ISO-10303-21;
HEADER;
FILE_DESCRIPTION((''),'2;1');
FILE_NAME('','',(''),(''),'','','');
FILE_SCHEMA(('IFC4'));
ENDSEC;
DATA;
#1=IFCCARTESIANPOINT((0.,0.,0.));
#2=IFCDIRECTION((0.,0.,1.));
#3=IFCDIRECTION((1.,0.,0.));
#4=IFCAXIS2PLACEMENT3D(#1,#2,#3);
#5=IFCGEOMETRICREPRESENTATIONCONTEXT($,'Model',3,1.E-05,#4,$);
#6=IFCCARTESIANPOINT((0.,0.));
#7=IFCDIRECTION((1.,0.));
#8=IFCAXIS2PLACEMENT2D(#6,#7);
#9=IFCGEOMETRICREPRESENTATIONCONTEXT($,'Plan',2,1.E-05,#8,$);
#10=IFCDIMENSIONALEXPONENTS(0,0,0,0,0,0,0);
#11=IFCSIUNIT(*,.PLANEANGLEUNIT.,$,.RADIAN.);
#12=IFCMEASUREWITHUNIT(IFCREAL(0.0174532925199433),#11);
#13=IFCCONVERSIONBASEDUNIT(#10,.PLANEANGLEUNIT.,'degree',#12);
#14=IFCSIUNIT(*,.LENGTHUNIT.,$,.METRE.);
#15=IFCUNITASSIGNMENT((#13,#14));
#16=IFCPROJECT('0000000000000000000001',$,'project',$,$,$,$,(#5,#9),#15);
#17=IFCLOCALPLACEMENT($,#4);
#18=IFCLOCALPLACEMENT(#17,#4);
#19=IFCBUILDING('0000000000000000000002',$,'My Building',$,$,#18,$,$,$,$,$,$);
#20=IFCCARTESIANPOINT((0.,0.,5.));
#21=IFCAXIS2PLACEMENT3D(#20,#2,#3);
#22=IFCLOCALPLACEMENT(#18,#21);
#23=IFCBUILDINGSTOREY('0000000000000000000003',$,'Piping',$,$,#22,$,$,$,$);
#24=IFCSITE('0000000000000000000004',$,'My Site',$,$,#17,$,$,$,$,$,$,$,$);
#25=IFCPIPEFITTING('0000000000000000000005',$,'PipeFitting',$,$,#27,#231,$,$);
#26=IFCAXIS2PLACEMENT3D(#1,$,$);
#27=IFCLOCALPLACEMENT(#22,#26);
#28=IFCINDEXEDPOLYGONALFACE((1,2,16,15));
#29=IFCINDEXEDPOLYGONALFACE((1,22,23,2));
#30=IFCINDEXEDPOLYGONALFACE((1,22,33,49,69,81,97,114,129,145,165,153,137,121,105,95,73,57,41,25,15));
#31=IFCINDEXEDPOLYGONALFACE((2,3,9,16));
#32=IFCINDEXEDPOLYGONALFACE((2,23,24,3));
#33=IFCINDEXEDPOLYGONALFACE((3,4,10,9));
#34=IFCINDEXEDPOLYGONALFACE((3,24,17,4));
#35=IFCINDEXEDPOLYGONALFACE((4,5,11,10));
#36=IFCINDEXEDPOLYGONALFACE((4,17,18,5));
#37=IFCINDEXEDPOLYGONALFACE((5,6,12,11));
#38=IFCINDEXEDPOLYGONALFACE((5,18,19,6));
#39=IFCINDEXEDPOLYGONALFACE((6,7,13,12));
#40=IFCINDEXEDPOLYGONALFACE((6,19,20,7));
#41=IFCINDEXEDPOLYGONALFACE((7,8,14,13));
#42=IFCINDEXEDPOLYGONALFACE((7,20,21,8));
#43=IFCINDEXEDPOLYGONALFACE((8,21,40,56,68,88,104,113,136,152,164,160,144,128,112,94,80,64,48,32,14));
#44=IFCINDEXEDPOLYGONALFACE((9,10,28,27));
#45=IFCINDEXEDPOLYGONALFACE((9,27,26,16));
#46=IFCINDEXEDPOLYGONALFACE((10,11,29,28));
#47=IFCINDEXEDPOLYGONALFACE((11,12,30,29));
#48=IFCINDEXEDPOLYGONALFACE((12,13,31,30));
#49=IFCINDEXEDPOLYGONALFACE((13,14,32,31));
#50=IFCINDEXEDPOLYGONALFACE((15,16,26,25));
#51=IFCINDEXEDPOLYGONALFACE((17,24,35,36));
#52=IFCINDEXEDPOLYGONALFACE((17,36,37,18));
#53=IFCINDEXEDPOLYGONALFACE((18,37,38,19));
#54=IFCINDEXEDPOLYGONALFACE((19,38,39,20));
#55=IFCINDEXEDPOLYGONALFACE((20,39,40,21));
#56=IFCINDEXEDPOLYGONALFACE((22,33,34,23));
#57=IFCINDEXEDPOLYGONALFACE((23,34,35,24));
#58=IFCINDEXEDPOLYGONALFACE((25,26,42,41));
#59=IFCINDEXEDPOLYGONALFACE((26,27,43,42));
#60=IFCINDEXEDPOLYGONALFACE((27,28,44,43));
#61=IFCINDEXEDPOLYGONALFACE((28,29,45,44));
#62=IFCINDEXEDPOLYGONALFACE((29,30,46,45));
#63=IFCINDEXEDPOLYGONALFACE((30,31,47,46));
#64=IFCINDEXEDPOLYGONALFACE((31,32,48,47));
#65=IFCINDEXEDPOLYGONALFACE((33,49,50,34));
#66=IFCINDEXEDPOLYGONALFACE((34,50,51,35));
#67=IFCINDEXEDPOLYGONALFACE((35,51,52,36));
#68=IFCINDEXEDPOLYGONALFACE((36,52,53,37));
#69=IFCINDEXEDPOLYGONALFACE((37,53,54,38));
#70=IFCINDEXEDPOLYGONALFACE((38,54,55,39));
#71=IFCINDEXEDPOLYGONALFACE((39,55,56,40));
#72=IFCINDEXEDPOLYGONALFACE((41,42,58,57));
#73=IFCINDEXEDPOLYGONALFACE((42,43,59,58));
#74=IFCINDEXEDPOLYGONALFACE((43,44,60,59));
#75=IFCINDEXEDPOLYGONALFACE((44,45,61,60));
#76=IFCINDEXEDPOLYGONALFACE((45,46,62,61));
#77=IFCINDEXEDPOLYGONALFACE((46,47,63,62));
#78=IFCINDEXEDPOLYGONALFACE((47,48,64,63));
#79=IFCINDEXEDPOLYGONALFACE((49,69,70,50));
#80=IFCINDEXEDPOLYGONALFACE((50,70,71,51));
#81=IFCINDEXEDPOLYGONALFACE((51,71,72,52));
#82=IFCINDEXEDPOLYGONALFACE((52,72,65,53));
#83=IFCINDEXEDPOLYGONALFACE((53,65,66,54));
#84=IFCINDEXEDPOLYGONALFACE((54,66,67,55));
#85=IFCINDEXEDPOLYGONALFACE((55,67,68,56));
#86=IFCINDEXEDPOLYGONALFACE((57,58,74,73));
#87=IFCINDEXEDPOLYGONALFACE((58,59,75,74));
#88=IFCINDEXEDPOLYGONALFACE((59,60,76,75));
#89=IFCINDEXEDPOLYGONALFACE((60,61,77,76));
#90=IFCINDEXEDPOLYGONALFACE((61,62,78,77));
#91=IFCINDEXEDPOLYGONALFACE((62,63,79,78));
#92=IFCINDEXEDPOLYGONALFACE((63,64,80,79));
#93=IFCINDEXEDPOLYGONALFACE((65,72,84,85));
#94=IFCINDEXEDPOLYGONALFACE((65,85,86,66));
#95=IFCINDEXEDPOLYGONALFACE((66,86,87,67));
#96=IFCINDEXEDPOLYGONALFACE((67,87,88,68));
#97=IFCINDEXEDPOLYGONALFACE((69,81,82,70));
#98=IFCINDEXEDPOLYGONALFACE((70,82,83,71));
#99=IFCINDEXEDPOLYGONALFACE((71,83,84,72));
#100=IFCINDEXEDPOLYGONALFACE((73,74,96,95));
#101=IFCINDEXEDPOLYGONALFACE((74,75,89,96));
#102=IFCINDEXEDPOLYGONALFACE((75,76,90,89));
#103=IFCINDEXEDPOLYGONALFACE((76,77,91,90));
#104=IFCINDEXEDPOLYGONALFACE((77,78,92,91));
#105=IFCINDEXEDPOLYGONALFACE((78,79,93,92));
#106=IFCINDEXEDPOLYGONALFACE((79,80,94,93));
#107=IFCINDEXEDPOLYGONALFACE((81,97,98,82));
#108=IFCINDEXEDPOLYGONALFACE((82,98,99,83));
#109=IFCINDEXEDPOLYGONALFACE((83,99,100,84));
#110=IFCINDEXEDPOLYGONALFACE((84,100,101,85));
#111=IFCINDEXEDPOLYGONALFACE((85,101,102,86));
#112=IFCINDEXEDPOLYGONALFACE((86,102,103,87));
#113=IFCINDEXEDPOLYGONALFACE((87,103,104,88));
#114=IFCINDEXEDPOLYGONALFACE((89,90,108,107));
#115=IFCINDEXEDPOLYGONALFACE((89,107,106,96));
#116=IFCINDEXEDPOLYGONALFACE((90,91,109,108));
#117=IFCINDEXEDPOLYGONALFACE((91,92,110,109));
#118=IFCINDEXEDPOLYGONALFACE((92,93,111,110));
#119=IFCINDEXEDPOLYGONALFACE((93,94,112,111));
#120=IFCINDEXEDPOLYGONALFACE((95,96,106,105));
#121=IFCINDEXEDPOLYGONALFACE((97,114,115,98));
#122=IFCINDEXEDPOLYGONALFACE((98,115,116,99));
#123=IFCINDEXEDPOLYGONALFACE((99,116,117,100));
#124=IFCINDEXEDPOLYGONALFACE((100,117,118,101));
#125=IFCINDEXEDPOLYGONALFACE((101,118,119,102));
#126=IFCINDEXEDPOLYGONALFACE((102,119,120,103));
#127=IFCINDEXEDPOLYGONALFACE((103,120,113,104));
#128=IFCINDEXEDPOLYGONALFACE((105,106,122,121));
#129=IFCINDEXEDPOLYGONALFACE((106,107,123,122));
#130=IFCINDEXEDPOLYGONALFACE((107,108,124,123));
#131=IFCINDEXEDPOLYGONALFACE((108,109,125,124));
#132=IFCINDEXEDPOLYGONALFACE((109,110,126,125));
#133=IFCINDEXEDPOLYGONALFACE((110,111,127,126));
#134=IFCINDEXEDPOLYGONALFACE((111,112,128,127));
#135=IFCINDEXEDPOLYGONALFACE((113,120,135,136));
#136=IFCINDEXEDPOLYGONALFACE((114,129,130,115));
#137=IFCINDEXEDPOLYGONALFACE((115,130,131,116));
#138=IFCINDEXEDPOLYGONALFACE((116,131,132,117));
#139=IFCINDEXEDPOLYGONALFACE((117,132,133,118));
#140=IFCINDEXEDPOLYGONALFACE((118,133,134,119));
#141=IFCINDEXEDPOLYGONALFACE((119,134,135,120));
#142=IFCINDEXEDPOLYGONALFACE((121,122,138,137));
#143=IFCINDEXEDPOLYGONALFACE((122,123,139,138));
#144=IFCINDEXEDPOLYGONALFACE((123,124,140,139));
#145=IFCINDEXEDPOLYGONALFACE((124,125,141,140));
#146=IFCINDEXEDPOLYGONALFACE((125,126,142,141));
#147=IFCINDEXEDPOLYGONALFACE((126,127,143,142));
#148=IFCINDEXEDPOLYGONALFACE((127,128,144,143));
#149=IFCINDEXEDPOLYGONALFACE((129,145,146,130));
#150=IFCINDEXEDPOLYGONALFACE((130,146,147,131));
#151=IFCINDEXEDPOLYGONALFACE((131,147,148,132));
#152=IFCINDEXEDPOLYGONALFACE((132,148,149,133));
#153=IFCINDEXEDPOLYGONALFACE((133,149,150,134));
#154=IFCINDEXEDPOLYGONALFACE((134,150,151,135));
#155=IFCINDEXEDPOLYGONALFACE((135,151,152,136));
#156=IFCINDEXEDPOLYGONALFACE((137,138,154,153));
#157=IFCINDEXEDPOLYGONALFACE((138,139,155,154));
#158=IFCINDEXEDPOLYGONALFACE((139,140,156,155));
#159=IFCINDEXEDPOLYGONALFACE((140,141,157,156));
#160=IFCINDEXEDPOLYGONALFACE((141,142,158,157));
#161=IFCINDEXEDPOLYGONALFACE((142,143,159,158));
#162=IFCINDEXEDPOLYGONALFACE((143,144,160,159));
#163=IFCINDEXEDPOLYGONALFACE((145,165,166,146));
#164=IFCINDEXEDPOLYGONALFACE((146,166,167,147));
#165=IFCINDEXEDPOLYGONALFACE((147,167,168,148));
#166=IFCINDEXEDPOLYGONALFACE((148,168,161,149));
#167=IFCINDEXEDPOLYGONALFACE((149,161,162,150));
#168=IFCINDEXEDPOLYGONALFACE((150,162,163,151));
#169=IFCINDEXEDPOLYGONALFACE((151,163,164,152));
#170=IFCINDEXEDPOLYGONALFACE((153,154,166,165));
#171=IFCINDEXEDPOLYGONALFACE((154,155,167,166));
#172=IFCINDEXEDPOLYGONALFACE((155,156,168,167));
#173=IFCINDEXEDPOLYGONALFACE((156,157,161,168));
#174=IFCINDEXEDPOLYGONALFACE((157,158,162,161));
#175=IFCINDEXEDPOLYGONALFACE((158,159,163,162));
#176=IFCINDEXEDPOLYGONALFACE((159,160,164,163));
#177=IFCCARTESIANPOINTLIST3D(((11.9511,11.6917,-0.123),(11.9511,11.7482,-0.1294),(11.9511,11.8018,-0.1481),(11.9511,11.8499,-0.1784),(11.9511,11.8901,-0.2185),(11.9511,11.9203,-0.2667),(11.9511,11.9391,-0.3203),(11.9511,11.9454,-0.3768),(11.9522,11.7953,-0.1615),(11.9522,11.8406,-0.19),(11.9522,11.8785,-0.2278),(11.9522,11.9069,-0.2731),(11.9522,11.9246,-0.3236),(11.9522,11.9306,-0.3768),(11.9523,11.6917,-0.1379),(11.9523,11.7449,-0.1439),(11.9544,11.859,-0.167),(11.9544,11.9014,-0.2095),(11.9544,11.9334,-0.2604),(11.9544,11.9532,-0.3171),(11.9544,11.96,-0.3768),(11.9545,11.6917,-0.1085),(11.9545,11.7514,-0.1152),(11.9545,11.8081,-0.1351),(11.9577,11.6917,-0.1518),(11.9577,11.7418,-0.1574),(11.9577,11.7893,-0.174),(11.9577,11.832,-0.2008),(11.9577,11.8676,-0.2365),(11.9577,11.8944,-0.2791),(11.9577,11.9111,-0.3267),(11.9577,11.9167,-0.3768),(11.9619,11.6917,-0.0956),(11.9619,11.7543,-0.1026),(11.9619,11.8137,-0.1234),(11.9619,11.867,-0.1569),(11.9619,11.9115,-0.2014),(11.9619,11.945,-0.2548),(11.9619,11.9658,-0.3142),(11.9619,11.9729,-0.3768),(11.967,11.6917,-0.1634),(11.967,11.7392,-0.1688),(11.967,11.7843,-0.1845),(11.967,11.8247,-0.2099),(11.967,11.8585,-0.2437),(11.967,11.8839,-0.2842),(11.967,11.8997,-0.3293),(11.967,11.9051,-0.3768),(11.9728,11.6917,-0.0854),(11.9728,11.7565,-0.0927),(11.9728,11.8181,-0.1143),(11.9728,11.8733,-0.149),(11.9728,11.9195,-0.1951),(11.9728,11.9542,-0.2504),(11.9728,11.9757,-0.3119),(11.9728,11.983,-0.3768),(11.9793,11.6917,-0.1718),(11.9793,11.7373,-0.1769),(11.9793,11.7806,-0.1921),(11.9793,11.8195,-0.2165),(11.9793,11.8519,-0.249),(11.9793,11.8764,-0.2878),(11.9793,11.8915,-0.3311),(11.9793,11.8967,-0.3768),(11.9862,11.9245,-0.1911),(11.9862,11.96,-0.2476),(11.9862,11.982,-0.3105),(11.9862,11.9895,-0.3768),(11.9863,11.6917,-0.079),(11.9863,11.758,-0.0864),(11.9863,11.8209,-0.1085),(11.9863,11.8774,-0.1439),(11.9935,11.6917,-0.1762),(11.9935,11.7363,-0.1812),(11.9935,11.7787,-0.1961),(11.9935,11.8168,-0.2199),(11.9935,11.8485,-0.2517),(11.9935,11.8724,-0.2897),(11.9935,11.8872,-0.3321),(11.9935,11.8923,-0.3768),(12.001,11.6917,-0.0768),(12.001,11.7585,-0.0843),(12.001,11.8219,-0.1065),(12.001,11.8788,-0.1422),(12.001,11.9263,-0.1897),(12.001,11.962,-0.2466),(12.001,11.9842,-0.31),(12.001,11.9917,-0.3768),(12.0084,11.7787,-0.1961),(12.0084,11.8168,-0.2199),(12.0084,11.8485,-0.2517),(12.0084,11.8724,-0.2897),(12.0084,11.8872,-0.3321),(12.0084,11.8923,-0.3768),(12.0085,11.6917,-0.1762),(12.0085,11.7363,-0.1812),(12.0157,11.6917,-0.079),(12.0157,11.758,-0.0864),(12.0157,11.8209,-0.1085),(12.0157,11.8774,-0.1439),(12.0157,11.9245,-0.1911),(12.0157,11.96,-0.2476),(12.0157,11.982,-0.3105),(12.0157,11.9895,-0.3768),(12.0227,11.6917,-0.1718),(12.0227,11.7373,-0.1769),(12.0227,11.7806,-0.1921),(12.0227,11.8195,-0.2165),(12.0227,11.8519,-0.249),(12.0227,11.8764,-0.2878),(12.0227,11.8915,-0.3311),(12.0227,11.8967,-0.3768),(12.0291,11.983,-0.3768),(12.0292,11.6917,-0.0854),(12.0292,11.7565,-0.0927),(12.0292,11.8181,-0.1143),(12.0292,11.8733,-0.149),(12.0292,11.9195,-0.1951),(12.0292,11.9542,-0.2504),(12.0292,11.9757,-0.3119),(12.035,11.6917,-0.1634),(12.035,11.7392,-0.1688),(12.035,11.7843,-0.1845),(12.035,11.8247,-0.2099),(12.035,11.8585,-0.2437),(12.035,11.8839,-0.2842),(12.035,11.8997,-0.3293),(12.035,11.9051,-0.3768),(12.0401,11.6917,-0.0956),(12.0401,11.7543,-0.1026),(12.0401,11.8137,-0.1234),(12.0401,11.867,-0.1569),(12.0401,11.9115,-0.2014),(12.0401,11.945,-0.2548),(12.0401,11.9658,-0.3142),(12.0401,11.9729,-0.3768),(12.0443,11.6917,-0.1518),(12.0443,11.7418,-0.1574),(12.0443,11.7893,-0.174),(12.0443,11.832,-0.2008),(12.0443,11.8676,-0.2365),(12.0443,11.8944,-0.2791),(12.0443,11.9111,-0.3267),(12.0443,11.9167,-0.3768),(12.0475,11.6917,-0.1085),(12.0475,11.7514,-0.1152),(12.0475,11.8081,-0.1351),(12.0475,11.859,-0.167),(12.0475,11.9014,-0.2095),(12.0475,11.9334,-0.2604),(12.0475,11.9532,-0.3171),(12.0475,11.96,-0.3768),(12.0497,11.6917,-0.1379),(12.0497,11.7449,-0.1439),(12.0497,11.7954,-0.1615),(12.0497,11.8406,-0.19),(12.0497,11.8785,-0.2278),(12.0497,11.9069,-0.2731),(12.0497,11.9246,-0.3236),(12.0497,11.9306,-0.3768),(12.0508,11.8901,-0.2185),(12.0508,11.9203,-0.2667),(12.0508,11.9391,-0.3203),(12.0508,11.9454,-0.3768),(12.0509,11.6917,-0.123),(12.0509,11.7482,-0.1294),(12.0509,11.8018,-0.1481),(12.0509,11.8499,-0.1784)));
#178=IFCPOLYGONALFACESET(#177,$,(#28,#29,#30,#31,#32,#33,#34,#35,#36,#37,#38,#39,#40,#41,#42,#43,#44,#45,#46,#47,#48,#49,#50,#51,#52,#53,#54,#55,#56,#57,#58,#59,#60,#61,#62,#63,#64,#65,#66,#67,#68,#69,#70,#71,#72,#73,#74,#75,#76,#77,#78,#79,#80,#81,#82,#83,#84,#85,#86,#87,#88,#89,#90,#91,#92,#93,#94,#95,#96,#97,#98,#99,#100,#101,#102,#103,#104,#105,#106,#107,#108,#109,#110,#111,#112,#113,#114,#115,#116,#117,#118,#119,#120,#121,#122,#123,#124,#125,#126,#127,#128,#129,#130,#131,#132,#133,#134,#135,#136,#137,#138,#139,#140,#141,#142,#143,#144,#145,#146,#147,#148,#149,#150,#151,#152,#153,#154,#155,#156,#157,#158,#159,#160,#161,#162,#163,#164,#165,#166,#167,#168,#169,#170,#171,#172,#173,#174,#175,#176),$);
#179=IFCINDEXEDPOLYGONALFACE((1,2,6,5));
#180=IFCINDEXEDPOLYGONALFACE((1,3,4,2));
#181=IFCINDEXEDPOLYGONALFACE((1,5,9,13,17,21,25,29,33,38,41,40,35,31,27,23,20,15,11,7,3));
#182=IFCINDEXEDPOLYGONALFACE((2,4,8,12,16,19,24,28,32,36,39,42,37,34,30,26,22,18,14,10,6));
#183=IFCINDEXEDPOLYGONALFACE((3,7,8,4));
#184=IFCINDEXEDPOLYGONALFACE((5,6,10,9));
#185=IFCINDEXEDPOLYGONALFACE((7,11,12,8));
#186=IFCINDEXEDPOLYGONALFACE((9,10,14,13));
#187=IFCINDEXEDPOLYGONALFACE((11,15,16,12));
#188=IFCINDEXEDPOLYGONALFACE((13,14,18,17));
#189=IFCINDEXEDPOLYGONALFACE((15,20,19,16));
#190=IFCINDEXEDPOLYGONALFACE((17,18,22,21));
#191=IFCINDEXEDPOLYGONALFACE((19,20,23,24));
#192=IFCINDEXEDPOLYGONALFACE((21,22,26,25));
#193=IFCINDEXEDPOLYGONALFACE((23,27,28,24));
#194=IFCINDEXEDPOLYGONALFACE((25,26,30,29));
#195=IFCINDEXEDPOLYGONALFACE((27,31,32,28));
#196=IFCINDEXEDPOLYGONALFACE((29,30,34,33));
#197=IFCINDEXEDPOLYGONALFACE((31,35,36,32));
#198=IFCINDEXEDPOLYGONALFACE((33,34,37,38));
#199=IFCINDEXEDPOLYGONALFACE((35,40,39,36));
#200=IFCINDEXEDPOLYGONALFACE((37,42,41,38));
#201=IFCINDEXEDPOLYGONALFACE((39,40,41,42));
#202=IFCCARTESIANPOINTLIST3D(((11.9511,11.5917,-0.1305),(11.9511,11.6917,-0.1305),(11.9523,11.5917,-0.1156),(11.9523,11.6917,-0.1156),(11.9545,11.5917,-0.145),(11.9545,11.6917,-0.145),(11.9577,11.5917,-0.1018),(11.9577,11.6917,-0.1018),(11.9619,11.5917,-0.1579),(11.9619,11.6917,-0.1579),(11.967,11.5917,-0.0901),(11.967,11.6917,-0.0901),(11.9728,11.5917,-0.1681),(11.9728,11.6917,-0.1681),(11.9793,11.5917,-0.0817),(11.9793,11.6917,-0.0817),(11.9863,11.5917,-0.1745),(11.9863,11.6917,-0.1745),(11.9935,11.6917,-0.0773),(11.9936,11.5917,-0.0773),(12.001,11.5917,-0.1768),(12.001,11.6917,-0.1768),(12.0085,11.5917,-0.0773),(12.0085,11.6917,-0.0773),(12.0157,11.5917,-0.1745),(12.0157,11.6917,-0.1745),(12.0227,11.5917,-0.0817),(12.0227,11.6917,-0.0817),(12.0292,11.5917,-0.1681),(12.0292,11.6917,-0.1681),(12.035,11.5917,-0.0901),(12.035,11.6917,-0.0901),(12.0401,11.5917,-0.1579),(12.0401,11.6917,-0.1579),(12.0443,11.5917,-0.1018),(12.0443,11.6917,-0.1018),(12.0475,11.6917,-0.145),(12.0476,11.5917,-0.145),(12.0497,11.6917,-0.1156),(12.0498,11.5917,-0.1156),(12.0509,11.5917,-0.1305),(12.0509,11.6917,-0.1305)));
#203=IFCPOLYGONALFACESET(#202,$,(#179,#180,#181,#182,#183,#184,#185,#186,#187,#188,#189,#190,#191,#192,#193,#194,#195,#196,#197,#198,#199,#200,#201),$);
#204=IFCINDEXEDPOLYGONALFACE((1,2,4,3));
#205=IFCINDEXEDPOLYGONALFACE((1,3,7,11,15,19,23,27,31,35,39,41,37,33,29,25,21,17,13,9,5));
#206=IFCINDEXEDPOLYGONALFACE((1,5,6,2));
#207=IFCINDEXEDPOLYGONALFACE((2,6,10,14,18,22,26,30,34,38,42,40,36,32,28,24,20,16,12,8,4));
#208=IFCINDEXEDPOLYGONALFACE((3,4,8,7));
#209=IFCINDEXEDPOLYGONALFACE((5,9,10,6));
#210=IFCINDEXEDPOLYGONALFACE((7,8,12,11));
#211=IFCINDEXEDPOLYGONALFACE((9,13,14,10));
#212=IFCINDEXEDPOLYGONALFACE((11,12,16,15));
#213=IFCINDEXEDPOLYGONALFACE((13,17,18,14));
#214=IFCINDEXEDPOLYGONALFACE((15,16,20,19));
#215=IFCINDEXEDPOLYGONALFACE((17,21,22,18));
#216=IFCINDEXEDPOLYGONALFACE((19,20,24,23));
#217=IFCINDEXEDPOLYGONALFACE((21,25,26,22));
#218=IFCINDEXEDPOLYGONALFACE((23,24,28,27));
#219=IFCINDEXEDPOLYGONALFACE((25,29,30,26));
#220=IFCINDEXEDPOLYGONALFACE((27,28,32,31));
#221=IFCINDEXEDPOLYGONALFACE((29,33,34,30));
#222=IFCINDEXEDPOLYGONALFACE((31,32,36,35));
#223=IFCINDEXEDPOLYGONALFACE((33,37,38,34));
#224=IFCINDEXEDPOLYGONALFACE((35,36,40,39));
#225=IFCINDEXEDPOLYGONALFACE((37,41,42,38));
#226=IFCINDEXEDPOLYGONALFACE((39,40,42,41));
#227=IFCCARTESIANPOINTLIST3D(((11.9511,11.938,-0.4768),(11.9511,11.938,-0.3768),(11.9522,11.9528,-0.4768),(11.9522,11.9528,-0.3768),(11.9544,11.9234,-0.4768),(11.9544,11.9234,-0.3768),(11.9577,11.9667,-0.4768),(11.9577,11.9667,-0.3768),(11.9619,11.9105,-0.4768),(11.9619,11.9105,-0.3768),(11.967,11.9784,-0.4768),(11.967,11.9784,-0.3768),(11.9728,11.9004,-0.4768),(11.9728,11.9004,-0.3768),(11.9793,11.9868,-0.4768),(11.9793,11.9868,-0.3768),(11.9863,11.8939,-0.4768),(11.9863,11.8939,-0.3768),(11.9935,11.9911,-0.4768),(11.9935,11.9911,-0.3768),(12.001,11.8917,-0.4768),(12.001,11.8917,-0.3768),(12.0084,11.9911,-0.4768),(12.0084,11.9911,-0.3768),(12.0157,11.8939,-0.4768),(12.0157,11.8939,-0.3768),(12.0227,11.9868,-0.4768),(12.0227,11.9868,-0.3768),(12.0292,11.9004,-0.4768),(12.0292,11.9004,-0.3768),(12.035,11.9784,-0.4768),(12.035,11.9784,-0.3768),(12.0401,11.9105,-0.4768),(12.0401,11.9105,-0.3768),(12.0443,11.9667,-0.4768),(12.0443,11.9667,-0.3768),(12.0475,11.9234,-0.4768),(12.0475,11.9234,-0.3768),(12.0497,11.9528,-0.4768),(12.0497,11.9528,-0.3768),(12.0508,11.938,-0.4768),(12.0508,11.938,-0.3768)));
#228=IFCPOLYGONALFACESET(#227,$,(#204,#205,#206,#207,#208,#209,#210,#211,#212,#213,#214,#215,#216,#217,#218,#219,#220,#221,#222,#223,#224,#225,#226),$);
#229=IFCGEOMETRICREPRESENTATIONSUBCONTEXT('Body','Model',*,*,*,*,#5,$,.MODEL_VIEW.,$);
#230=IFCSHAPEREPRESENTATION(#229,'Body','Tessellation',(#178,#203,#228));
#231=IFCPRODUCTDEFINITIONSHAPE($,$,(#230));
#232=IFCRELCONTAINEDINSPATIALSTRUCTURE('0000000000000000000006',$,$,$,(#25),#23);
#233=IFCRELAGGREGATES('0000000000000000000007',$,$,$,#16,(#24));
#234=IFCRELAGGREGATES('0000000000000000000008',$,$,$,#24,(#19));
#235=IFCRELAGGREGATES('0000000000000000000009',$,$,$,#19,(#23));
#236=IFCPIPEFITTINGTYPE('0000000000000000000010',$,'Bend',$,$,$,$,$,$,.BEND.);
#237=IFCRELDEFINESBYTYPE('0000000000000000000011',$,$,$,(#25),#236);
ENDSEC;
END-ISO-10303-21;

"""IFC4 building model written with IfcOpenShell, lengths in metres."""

from ifc_helpers import new_model, entity, si_unit, converted_unit, frame, origin_with_axes, origin_2d_with_axis, place, context, subcontext, project, spatial, circle, extrude, source, transform, mapped, type_object, type_shapes, element, save


model = new_model("IFC4")

# Units and contexts
model_context = context("Model", 3, precision=1e-05, world=origin_with_axes())
plan_context = context("Plan", 2, precision=1e-05, world=origin_2d_with_axis())
body_context = subcontext(model_context, "Body", "Model", "MODEL_VIEW")
ifc_project = project(units=[converted_unit("PLANEANGLEUNIT", "degree", entity("IfcReal", 0.0174532925199433), si_unit("PLANEANGLEUNIT", "RADIAN"), dimensions=[0, 0, 0, 0, 0, 0, 0]), si_unit("LENGTHUNIT", "METRE")], contexts=[model_context, plan_context])

# Site, building, storey
site_placement = place(None, origin_with_axes())
site = spatial("IfcSite", under=ifc_project, at=site_placement, Name="My Site")
building_placement = place(site_placement, origin_with_axes())
building = spatial("IfcBuilding", under=site, at=building_placement, Name="My Building")
storey_placement = place(building_placement, frame((0.0, 0.0, 5.0), z_axis=(0.0, 0.0, 1.0), x_axis=(1.0, 0.0, 0.0)))
storey = spatial("IfcBuildingStorey", under=building, at=storey_placement, Name="Piping")

# Pipe fitting
pipe_fitting_type_1 = type_object("IfcPipeFittingType", Name="Bend", PredefinedType="BEND")
shared_shape = source(origin_with_axes(), body_context, "Body", "SolidModel", [
    entity("IfcSweptDiskSolid", entity("IfcIndexedPolyCurve", entity("IfcCartesianPointList3D", [[0.0, 0.0, -0.1], [0.0732, 0.0, -0.2768], [0.25, 0.0, -0.35]]), [entity("IfcArcIndex", [1, 2, 3])]), 0.05),
    extrude(circle(Radius=0.05), origin_with_axes(), (0.0, 0.0, -1.0), 0.1),
    extrude(circle(Radius=0.05), frame((0.25, 0.0, -0.35), z_axis=(1.0, 0.0, 0.0), x_axis=(0.0, 0.0, 1.0)), (0.0, 0.0, 1.0), 0.1),
])
type_shapes(pipe_fitting_type_1, [shared_shape])
for number, where, z_axis, x_axis, name in (
    (1, (12.001, 11.5917, -0.1268), (0.00006, -1.0, 0.0), (0.0, 0.0, -1.0), "PipeFitting"),
):
    element("IfcPipeFitting", number, at=place(storey_placement, frame(where, z_axis=z_axis, x_axis=x_axis)), inside=storey, type_object=pipe_fitting_type_1, Name=name, context=body_context, shape_type="MappedRepresentation", body=[
        mapped(shared_shape, transform((0.0, 0.0, 0.0), x_axis=(1.0, 0.0, 0.0), y_axis=(0.0, 1.0, 0.0), z_axis=(0.0, 0.0, 1.0), scale=1.0)),
    ])

save(model, "model.ifc")
